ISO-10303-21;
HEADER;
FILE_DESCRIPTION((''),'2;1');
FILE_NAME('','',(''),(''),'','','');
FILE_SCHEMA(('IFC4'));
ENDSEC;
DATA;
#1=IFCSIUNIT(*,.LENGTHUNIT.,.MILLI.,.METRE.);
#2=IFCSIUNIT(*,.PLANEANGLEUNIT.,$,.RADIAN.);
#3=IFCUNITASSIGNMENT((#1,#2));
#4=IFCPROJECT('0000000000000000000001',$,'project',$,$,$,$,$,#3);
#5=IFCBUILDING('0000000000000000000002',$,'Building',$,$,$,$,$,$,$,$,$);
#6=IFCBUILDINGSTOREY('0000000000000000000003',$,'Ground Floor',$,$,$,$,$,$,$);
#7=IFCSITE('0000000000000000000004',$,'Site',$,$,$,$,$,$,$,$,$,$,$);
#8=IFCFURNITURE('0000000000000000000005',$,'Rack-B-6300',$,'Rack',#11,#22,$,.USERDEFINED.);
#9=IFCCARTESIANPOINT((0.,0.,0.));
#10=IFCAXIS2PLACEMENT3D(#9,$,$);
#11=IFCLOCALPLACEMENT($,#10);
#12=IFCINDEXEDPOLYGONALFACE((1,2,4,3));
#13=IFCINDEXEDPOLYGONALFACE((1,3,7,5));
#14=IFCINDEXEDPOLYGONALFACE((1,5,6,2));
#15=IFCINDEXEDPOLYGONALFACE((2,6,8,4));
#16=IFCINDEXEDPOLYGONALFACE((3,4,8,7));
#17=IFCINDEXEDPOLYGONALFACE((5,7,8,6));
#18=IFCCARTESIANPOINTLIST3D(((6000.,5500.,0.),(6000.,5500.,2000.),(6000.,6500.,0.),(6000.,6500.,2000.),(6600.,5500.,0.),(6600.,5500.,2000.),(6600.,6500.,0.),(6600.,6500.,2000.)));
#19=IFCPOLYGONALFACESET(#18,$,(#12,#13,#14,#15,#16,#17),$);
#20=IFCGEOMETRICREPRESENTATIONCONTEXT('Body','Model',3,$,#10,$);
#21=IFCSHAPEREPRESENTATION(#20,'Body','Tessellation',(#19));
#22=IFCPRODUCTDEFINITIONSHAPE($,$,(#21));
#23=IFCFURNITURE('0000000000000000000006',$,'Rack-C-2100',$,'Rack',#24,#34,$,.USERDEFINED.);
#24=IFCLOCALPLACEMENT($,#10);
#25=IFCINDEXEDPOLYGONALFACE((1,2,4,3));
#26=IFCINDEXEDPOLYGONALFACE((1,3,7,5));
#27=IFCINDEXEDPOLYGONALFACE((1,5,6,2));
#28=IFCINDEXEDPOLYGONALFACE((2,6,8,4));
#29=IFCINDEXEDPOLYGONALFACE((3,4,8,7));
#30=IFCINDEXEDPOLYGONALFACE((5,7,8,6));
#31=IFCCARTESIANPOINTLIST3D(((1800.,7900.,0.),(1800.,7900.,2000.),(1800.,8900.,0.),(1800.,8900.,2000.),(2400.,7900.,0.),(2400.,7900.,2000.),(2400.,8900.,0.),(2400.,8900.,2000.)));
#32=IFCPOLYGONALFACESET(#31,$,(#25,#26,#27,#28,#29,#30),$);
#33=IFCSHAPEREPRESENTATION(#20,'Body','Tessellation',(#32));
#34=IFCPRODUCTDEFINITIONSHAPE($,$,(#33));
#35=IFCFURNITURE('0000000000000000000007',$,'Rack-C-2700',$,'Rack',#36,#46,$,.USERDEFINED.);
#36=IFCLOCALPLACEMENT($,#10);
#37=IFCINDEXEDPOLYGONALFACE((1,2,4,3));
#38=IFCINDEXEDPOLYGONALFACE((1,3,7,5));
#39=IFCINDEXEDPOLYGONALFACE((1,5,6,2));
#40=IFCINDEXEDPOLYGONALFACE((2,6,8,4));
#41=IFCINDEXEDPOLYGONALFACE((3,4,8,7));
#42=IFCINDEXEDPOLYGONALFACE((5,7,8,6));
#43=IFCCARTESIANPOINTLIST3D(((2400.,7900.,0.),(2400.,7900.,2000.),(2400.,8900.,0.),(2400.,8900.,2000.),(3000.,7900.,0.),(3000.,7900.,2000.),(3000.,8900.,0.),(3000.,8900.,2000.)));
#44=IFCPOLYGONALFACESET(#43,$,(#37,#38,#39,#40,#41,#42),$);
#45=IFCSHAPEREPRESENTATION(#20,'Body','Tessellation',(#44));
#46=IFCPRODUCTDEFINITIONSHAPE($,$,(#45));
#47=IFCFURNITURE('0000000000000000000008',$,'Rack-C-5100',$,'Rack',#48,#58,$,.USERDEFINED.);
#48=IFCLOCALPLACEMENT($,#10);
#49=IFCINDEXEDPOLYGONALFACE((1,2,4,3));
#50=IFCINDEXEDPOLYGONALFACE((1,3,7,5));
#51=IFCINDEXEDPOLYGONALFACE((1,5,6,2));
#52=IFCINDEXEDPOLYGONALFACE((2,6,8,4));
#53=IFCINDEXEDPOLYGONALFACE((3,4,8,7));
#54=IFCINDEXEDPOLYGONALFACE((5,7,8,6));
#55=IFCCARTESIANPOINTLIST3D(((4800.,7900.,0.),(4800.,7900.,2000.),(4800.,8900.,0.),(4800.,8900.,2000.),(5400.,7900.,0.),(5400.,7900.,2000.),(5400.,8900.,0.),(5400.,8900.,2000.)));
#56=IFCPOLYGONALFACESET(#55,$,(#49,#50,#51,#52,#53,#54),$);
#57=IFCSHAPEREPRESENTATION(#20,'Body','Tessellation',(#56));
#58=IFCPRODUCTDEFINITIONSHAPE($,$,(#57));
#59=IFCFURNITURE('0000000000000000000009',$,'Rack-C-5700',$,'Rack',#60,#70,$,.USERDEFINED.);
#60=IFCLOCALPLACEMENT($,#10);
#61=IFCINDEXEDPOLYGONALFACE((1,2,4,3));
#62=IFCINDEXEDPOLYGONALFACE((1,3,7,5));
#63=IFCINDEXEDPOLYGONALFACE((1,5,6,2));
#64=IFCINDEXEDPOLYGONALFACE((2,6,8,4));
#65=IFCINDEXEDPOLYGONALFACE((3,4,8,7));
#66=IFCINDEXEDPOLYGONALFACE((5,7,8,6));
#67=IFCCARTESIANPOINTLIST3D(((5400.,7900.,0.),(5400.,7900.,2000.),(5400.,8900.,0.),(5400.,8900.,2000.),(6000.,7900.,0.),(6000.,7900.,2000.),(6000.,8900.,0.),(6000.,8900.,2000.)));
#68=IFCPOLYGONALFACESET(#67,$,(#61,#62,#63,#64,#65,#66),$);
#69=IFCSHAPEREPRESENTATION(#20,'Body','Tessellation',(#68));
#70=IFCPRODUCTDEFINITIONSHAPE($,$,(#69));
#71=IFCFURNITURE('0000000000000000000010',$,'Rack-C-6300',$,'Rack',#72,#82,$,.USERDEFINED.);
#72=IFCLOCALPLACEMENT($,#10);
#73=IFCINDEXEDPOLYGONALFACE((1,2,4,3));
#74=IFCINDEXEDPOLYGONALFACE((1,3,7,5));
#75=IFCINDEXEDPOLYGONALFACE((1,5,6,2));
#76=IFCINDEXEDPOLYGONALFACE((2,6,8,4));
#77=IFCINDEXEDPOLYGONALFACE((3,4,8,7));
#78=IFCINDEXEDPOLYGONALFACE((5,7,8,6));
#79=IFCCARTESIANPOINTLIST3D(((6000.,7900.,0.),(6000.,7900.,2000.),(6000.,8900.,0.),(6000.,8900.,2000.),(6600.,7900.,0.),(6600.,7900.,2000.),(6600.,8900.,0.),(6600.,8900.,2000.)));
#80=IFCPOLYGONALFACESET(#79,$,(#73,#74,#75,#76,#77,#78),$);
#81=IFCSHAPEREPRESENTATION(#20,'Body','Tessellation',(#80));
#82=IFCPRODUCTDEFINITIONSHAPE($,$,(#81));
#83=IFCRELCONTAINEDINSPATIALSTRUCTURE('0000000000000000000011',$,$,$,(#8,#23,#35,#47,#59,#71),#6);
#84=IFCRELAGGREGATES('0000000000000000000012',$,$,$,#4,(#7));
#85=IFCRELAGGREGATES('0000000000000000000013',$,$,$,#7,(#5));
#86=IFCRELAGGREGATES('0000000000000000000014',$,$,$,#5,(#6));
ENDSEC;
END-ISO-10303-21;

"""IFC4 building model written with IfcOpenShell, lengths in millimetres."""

from ifc_helpers import new_model, si_unit, frame, origin, place, context, project, spatial, rectangle, extrude, element, save


model = new_model("IFC4")

# Units and contexts
model_context = context("Model", 3, world=origin(), identifier="Body")
ifc_project = project(units=[si_unit("LENGTHUNIT", "METRE", prefix="MILLI"), si_unit("PLANEANGLEUNIT", "RADIAN")])

# Site, building, storey
site = spatial("IfcSite", under=ifc_project, Name="Site")
building = spatial("IfcBuilding", under=site, Name="Building")
storey = spatial("IfcBuildingStorey", under=building, Name="Ground Floor")

# Furniture
for number, where, z_axis, x_axis, name in (
    (1, (6300.0, 6000.0, 0.0), (0.0, 0.0, 1.0), (1.0, 0.0, 0.0), "Rack-B-6300"),
    (2, (2100.0, 8400.0, 0.0), (0.0, 0.0, 1.0), (1.0, 0.0, 0.0), "Rack-C-2100"),
    (3, (2700.0, 8400.0, 0.0), (0.0, 0.0, 1.0), (1.0, 0.0, 0.0), "Rack-C-2700"),
    (4, (5100.0, 8400.0, 0.0), (0.0, 0.0, 1.0), (1.0, 0.0, 0.0), "Rack-C-5100"),
    (5, (5700.0, 8400.0, 0.0), (0.0, 0.0, 1.0), (1.0, 0.0, 0.0), "Rack-C-5700"),
    (6, (6300.0, 8400.0, 0.0), (0.0, 0.0, 1.0), (1.0, 0.0, 0.0), "Rack-C-6300"),
):
    element("IfcFurniture", number, at=place(None, frame(where, z_axis=z_axis, x_axis=x_axis)), inside=storey, Name=name, ObjectType="Rack", PredefinedType="USERDEFINED", context=model_context, shape_type="SweptSolid", body=[
        extrude(rectangle(XDim=600.0, YDim=1000.0), origin(), (0.0, 0.0, 1.0), 2000.0),
    ])

save(model, "model.ifc")
